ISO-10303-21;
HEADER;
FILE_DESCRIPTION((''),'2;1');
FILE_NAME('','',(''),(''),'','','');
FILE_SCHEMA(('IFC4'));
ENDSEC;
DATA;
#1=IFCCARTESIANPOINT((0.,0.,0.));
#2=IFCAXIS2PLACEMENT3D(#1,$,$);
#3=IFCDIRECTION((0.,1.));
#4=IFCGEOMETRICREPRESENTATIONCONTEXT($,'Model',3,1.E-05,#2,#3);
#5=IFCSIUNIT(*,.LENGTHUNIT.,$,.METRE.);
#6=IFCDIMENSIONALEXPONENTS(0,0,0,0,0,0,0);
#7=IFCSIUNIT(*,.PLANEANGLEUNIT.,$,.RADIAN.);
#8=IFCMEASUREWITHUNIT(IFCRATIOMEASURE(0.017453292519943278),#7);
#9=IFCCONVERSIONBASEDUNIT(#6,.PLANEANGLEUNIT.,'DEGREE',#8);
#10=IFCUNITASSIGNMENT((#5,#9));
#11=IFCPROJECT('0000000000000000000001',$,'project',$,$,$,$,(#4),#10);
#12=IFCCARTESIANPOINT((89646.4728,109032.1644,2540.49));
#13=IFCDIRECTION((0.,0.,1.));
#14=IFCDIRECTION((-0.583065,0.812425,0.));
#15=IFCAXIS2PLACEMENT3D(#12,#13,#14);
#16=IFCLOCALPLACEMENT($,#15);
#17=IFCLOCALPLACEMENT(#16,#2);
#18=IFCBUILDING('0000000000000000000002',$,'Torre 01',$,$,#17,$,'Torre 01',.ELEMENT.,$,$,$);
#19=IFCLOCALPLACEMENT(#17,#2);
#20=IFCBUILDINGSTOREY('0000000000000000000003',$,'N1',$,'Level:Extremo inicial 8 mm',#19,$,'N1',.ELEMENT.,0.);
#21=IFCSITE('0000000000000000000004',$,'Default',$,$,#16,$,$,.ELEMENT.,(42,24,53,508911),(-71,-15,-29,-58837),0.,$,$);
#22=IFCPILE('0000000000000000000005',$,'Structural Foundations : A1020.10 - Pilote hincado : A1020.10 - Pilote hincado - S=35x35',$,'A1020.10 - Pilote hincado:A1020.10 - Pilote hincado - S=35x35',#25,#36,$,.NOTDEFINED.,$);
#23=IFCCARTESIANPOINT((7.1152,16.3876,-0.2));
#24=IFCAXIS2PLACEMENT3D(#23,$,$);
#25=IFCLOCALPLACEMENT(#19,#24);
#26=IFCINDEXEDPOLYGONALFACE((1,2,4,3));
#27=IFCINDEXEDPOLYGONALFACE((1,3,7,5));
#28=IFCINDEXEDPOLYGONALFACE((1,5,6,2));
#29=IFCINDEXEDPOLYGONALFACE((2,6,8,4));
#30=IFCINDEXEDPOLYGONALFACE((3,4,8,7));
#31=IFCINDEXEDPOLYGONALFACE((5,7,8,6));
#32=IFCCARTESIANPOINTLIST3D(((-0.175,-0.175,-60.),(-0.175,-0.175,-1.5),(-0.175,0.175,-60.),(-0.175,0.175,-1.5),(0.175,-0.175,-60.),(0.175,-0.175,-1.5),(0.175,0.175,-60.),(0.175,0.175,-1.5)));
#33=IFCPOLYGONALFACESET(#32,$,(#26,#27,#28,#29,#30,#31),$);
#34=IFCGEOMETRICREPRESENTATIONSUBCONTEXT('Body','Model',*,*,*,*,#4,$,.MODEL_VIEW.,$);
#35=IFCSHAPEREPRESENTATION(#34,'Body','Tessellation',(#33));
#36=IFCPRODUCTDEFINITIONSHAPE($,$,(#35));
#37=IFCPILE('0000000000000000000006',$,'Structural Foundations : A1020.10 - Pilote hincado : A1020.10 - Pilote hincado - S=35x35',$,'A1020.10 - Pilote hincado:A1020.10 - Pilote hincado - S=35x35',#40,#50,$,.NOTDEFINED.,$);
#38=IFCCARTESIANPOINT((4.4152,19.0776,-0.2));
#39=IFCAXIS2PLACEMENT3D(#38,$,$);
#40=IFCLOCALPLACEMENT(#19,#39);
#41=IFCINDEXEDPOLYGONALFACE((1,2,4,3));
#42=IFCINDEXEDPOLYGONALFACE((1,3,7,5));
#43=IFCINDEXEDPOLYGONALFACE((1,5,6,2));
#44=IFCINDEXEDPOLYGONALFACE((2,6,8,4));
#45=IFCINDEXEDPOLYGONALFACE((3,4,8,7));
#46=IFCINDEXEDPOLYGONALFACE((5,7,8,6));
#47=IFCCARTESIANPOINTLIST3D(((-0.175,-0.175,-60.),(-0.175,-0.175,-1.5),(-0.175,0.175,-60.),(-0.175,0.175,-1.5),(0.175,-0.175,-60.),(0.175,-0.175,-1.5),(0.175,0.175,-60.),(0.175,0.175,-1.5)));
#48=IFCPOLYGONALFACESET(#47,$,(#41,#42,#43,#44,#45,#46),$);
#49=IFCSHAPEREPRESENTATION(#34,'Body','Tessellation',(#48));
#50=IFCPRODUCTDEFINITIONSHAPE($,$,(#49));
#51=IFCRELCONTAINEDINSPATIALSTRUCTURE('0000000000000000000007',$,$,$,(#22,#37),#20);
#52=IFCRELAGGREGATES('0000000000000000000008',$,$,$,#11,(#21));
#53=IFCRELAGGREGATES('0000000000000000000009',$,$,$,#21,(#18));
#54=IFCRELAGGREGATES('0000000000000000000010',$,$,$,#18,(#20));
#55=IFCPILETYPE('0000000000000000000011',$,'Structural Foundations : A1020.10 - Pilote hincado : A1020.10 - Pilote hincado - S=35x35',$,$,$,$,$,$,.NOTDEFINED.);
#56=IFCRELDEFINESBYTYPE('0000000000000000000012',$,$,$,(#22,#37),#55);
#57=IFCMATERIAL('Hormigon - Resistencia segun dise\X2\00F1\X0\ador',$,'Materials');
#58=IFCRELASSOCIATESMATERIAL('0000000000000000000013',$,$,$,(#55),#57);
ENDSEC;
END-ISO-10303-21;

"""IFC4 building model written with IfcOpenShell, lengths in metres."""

from ifc_helpers import new_model, entity, si_unit, converted_unit, direction, frame, origin, origin_2d_with_axis, place, context, subcontext, project, spatial, polyline, segment, composite_curve, rectangle, outline, extrude, source, transform, mapped, material, material_profile, profile_set, type_object, type_shapes, element, save


model = new_model("IFC4")

# Units and contexts
model_context = context("Model", 3, precision=1e-05, world=origin(), true_north=direction((0.0, 1.0)))
body_context = subcontext(model_context, "Body", "Model", "MODEL_VIEW")
ifc_project = project(units=[si_unit("LENGTHUNIT", "METRE"), converted_unit("PLANEANGLEUNIT", "DEGREE", entity("IfcRatioMeasure", 0.017453292519943278), si_unit("PLANEANGLEUNIT", "RADIAN"), dimensions=[0, 0, 0, 0, 0, 0, 0])], contexts=[model_context])

# Site, building, storey
site_placement = place(None, frame((89646.4728, 109032.1644, 2540.49), z_axis=(0.0, 0.0, 1.0), x_axis=(-0.583065, 0.812425, 0.0)))
site = spatial("IfcSite", under=ifc_project, at=site_placement, Name="Default", CompositionType="ELEMENT", RefLatitude=(42, 24, 53, 508911), RefLongitude=(-71, -15, -29, -58837), RefElevation=0.0)
building_placement = place(site_placement, origin())
building = spatial("IfcBuilding", under=site, at=building_placement, Name="Torre 01", LongName="Torre 01", CompositionType="ELEMENT")
storey_placement = place(building_placement, origin())
storey = spatial("IfcBuildingStorey", under=building, at=storey_placement, Name="N1", ObjectType="Level:Extremo inicial 8 mm", LongName="N1", CompositionType="ELEMENT", Elevation=0.0)

# Piles
ifc_material_1 = material(Name="Hormigon - Resistencia segun diseñador", Category="Materials")
ifc_material_profile_1 = material_profile(ifc_material_1, outline(composite_curve([segment(polyline([(0.175, -0.175, -60.0), (-0.175, -0.175, -60.0)]), True, "CONTINUOUS"), segment(polyline([(-0.175, -0.175, -60.0), (-0.175, 0.175, -60.0)]), True, "CONTINUOUS"), segment(polyline([(-0.175, 0.175, -60.0), (0.175, 0.175, -60.0)]), True, "CONTINUOUS"), segment(polyline([(0.175, 0.175, -60.0), (0.175, -0.175, -60.0)]), True, "CONTINUOUS")], self_intersect=False), kind="CURVE"), Name="A1020.10 - Pilote hincado - S=35x35")
ifc_profile_set_1 = profile_set([ifc_material_profile_1], Name="A1020.10 - Pilote hincado - S=35x35")
pile_type = type_object("IfcPileType", Name="Structural Foundations : A1020.10 - Pilote hincado : A1020.10 - Pilote hincado - S=35x35", PredefinedType="NOTDEFINED", material=ifc_profile_set_1)
shared_shape_1 = source(origin(), body_context, "Body", "SweptSolid", [
    extrude(rectangle(XDim=0.35, YDim=0.35, at=origin_2d_with_axis()), frame((0.0, 0.0, -60.0), z_axis=(0.0, 0.0, 1.0), x_axis=(0.0, -1.0, 0.0)), (0.0, 0.0, 1.0), 58.5),
])
type_shapes(pile_type, [shared_shape_1])
for number, where, name in (
    (1, (7.1152, 16.3876, -0.2), "Structural Foundations : A1020.10 - Pilote hincado : A1020.10 - Pilote hincado - S=35x35"),
    (2, (4.4152, 19.0776, -0.2), "Structural Foundations : A1020.10 - Pilote hincado : A1020.10 - Pilote hincado - S=35x35"),
):
    element("IfcPile", number, at=place(storey_placement, frame(where)), inside=storey, type_object=pile_type, Name=name, ObjectType="A1020.10 - Pilote hincado:A1020.10 - Pilote hincado - S=35x35", PredefinedType="NOTDEFINED", context=body_context, shape_type="MappedRepresentation", body=[
        mapped(shared_shape_1, transform((0.0, 0.0, 0.0), scale=1.0)),
    ])

save(model, "model.ifc")
